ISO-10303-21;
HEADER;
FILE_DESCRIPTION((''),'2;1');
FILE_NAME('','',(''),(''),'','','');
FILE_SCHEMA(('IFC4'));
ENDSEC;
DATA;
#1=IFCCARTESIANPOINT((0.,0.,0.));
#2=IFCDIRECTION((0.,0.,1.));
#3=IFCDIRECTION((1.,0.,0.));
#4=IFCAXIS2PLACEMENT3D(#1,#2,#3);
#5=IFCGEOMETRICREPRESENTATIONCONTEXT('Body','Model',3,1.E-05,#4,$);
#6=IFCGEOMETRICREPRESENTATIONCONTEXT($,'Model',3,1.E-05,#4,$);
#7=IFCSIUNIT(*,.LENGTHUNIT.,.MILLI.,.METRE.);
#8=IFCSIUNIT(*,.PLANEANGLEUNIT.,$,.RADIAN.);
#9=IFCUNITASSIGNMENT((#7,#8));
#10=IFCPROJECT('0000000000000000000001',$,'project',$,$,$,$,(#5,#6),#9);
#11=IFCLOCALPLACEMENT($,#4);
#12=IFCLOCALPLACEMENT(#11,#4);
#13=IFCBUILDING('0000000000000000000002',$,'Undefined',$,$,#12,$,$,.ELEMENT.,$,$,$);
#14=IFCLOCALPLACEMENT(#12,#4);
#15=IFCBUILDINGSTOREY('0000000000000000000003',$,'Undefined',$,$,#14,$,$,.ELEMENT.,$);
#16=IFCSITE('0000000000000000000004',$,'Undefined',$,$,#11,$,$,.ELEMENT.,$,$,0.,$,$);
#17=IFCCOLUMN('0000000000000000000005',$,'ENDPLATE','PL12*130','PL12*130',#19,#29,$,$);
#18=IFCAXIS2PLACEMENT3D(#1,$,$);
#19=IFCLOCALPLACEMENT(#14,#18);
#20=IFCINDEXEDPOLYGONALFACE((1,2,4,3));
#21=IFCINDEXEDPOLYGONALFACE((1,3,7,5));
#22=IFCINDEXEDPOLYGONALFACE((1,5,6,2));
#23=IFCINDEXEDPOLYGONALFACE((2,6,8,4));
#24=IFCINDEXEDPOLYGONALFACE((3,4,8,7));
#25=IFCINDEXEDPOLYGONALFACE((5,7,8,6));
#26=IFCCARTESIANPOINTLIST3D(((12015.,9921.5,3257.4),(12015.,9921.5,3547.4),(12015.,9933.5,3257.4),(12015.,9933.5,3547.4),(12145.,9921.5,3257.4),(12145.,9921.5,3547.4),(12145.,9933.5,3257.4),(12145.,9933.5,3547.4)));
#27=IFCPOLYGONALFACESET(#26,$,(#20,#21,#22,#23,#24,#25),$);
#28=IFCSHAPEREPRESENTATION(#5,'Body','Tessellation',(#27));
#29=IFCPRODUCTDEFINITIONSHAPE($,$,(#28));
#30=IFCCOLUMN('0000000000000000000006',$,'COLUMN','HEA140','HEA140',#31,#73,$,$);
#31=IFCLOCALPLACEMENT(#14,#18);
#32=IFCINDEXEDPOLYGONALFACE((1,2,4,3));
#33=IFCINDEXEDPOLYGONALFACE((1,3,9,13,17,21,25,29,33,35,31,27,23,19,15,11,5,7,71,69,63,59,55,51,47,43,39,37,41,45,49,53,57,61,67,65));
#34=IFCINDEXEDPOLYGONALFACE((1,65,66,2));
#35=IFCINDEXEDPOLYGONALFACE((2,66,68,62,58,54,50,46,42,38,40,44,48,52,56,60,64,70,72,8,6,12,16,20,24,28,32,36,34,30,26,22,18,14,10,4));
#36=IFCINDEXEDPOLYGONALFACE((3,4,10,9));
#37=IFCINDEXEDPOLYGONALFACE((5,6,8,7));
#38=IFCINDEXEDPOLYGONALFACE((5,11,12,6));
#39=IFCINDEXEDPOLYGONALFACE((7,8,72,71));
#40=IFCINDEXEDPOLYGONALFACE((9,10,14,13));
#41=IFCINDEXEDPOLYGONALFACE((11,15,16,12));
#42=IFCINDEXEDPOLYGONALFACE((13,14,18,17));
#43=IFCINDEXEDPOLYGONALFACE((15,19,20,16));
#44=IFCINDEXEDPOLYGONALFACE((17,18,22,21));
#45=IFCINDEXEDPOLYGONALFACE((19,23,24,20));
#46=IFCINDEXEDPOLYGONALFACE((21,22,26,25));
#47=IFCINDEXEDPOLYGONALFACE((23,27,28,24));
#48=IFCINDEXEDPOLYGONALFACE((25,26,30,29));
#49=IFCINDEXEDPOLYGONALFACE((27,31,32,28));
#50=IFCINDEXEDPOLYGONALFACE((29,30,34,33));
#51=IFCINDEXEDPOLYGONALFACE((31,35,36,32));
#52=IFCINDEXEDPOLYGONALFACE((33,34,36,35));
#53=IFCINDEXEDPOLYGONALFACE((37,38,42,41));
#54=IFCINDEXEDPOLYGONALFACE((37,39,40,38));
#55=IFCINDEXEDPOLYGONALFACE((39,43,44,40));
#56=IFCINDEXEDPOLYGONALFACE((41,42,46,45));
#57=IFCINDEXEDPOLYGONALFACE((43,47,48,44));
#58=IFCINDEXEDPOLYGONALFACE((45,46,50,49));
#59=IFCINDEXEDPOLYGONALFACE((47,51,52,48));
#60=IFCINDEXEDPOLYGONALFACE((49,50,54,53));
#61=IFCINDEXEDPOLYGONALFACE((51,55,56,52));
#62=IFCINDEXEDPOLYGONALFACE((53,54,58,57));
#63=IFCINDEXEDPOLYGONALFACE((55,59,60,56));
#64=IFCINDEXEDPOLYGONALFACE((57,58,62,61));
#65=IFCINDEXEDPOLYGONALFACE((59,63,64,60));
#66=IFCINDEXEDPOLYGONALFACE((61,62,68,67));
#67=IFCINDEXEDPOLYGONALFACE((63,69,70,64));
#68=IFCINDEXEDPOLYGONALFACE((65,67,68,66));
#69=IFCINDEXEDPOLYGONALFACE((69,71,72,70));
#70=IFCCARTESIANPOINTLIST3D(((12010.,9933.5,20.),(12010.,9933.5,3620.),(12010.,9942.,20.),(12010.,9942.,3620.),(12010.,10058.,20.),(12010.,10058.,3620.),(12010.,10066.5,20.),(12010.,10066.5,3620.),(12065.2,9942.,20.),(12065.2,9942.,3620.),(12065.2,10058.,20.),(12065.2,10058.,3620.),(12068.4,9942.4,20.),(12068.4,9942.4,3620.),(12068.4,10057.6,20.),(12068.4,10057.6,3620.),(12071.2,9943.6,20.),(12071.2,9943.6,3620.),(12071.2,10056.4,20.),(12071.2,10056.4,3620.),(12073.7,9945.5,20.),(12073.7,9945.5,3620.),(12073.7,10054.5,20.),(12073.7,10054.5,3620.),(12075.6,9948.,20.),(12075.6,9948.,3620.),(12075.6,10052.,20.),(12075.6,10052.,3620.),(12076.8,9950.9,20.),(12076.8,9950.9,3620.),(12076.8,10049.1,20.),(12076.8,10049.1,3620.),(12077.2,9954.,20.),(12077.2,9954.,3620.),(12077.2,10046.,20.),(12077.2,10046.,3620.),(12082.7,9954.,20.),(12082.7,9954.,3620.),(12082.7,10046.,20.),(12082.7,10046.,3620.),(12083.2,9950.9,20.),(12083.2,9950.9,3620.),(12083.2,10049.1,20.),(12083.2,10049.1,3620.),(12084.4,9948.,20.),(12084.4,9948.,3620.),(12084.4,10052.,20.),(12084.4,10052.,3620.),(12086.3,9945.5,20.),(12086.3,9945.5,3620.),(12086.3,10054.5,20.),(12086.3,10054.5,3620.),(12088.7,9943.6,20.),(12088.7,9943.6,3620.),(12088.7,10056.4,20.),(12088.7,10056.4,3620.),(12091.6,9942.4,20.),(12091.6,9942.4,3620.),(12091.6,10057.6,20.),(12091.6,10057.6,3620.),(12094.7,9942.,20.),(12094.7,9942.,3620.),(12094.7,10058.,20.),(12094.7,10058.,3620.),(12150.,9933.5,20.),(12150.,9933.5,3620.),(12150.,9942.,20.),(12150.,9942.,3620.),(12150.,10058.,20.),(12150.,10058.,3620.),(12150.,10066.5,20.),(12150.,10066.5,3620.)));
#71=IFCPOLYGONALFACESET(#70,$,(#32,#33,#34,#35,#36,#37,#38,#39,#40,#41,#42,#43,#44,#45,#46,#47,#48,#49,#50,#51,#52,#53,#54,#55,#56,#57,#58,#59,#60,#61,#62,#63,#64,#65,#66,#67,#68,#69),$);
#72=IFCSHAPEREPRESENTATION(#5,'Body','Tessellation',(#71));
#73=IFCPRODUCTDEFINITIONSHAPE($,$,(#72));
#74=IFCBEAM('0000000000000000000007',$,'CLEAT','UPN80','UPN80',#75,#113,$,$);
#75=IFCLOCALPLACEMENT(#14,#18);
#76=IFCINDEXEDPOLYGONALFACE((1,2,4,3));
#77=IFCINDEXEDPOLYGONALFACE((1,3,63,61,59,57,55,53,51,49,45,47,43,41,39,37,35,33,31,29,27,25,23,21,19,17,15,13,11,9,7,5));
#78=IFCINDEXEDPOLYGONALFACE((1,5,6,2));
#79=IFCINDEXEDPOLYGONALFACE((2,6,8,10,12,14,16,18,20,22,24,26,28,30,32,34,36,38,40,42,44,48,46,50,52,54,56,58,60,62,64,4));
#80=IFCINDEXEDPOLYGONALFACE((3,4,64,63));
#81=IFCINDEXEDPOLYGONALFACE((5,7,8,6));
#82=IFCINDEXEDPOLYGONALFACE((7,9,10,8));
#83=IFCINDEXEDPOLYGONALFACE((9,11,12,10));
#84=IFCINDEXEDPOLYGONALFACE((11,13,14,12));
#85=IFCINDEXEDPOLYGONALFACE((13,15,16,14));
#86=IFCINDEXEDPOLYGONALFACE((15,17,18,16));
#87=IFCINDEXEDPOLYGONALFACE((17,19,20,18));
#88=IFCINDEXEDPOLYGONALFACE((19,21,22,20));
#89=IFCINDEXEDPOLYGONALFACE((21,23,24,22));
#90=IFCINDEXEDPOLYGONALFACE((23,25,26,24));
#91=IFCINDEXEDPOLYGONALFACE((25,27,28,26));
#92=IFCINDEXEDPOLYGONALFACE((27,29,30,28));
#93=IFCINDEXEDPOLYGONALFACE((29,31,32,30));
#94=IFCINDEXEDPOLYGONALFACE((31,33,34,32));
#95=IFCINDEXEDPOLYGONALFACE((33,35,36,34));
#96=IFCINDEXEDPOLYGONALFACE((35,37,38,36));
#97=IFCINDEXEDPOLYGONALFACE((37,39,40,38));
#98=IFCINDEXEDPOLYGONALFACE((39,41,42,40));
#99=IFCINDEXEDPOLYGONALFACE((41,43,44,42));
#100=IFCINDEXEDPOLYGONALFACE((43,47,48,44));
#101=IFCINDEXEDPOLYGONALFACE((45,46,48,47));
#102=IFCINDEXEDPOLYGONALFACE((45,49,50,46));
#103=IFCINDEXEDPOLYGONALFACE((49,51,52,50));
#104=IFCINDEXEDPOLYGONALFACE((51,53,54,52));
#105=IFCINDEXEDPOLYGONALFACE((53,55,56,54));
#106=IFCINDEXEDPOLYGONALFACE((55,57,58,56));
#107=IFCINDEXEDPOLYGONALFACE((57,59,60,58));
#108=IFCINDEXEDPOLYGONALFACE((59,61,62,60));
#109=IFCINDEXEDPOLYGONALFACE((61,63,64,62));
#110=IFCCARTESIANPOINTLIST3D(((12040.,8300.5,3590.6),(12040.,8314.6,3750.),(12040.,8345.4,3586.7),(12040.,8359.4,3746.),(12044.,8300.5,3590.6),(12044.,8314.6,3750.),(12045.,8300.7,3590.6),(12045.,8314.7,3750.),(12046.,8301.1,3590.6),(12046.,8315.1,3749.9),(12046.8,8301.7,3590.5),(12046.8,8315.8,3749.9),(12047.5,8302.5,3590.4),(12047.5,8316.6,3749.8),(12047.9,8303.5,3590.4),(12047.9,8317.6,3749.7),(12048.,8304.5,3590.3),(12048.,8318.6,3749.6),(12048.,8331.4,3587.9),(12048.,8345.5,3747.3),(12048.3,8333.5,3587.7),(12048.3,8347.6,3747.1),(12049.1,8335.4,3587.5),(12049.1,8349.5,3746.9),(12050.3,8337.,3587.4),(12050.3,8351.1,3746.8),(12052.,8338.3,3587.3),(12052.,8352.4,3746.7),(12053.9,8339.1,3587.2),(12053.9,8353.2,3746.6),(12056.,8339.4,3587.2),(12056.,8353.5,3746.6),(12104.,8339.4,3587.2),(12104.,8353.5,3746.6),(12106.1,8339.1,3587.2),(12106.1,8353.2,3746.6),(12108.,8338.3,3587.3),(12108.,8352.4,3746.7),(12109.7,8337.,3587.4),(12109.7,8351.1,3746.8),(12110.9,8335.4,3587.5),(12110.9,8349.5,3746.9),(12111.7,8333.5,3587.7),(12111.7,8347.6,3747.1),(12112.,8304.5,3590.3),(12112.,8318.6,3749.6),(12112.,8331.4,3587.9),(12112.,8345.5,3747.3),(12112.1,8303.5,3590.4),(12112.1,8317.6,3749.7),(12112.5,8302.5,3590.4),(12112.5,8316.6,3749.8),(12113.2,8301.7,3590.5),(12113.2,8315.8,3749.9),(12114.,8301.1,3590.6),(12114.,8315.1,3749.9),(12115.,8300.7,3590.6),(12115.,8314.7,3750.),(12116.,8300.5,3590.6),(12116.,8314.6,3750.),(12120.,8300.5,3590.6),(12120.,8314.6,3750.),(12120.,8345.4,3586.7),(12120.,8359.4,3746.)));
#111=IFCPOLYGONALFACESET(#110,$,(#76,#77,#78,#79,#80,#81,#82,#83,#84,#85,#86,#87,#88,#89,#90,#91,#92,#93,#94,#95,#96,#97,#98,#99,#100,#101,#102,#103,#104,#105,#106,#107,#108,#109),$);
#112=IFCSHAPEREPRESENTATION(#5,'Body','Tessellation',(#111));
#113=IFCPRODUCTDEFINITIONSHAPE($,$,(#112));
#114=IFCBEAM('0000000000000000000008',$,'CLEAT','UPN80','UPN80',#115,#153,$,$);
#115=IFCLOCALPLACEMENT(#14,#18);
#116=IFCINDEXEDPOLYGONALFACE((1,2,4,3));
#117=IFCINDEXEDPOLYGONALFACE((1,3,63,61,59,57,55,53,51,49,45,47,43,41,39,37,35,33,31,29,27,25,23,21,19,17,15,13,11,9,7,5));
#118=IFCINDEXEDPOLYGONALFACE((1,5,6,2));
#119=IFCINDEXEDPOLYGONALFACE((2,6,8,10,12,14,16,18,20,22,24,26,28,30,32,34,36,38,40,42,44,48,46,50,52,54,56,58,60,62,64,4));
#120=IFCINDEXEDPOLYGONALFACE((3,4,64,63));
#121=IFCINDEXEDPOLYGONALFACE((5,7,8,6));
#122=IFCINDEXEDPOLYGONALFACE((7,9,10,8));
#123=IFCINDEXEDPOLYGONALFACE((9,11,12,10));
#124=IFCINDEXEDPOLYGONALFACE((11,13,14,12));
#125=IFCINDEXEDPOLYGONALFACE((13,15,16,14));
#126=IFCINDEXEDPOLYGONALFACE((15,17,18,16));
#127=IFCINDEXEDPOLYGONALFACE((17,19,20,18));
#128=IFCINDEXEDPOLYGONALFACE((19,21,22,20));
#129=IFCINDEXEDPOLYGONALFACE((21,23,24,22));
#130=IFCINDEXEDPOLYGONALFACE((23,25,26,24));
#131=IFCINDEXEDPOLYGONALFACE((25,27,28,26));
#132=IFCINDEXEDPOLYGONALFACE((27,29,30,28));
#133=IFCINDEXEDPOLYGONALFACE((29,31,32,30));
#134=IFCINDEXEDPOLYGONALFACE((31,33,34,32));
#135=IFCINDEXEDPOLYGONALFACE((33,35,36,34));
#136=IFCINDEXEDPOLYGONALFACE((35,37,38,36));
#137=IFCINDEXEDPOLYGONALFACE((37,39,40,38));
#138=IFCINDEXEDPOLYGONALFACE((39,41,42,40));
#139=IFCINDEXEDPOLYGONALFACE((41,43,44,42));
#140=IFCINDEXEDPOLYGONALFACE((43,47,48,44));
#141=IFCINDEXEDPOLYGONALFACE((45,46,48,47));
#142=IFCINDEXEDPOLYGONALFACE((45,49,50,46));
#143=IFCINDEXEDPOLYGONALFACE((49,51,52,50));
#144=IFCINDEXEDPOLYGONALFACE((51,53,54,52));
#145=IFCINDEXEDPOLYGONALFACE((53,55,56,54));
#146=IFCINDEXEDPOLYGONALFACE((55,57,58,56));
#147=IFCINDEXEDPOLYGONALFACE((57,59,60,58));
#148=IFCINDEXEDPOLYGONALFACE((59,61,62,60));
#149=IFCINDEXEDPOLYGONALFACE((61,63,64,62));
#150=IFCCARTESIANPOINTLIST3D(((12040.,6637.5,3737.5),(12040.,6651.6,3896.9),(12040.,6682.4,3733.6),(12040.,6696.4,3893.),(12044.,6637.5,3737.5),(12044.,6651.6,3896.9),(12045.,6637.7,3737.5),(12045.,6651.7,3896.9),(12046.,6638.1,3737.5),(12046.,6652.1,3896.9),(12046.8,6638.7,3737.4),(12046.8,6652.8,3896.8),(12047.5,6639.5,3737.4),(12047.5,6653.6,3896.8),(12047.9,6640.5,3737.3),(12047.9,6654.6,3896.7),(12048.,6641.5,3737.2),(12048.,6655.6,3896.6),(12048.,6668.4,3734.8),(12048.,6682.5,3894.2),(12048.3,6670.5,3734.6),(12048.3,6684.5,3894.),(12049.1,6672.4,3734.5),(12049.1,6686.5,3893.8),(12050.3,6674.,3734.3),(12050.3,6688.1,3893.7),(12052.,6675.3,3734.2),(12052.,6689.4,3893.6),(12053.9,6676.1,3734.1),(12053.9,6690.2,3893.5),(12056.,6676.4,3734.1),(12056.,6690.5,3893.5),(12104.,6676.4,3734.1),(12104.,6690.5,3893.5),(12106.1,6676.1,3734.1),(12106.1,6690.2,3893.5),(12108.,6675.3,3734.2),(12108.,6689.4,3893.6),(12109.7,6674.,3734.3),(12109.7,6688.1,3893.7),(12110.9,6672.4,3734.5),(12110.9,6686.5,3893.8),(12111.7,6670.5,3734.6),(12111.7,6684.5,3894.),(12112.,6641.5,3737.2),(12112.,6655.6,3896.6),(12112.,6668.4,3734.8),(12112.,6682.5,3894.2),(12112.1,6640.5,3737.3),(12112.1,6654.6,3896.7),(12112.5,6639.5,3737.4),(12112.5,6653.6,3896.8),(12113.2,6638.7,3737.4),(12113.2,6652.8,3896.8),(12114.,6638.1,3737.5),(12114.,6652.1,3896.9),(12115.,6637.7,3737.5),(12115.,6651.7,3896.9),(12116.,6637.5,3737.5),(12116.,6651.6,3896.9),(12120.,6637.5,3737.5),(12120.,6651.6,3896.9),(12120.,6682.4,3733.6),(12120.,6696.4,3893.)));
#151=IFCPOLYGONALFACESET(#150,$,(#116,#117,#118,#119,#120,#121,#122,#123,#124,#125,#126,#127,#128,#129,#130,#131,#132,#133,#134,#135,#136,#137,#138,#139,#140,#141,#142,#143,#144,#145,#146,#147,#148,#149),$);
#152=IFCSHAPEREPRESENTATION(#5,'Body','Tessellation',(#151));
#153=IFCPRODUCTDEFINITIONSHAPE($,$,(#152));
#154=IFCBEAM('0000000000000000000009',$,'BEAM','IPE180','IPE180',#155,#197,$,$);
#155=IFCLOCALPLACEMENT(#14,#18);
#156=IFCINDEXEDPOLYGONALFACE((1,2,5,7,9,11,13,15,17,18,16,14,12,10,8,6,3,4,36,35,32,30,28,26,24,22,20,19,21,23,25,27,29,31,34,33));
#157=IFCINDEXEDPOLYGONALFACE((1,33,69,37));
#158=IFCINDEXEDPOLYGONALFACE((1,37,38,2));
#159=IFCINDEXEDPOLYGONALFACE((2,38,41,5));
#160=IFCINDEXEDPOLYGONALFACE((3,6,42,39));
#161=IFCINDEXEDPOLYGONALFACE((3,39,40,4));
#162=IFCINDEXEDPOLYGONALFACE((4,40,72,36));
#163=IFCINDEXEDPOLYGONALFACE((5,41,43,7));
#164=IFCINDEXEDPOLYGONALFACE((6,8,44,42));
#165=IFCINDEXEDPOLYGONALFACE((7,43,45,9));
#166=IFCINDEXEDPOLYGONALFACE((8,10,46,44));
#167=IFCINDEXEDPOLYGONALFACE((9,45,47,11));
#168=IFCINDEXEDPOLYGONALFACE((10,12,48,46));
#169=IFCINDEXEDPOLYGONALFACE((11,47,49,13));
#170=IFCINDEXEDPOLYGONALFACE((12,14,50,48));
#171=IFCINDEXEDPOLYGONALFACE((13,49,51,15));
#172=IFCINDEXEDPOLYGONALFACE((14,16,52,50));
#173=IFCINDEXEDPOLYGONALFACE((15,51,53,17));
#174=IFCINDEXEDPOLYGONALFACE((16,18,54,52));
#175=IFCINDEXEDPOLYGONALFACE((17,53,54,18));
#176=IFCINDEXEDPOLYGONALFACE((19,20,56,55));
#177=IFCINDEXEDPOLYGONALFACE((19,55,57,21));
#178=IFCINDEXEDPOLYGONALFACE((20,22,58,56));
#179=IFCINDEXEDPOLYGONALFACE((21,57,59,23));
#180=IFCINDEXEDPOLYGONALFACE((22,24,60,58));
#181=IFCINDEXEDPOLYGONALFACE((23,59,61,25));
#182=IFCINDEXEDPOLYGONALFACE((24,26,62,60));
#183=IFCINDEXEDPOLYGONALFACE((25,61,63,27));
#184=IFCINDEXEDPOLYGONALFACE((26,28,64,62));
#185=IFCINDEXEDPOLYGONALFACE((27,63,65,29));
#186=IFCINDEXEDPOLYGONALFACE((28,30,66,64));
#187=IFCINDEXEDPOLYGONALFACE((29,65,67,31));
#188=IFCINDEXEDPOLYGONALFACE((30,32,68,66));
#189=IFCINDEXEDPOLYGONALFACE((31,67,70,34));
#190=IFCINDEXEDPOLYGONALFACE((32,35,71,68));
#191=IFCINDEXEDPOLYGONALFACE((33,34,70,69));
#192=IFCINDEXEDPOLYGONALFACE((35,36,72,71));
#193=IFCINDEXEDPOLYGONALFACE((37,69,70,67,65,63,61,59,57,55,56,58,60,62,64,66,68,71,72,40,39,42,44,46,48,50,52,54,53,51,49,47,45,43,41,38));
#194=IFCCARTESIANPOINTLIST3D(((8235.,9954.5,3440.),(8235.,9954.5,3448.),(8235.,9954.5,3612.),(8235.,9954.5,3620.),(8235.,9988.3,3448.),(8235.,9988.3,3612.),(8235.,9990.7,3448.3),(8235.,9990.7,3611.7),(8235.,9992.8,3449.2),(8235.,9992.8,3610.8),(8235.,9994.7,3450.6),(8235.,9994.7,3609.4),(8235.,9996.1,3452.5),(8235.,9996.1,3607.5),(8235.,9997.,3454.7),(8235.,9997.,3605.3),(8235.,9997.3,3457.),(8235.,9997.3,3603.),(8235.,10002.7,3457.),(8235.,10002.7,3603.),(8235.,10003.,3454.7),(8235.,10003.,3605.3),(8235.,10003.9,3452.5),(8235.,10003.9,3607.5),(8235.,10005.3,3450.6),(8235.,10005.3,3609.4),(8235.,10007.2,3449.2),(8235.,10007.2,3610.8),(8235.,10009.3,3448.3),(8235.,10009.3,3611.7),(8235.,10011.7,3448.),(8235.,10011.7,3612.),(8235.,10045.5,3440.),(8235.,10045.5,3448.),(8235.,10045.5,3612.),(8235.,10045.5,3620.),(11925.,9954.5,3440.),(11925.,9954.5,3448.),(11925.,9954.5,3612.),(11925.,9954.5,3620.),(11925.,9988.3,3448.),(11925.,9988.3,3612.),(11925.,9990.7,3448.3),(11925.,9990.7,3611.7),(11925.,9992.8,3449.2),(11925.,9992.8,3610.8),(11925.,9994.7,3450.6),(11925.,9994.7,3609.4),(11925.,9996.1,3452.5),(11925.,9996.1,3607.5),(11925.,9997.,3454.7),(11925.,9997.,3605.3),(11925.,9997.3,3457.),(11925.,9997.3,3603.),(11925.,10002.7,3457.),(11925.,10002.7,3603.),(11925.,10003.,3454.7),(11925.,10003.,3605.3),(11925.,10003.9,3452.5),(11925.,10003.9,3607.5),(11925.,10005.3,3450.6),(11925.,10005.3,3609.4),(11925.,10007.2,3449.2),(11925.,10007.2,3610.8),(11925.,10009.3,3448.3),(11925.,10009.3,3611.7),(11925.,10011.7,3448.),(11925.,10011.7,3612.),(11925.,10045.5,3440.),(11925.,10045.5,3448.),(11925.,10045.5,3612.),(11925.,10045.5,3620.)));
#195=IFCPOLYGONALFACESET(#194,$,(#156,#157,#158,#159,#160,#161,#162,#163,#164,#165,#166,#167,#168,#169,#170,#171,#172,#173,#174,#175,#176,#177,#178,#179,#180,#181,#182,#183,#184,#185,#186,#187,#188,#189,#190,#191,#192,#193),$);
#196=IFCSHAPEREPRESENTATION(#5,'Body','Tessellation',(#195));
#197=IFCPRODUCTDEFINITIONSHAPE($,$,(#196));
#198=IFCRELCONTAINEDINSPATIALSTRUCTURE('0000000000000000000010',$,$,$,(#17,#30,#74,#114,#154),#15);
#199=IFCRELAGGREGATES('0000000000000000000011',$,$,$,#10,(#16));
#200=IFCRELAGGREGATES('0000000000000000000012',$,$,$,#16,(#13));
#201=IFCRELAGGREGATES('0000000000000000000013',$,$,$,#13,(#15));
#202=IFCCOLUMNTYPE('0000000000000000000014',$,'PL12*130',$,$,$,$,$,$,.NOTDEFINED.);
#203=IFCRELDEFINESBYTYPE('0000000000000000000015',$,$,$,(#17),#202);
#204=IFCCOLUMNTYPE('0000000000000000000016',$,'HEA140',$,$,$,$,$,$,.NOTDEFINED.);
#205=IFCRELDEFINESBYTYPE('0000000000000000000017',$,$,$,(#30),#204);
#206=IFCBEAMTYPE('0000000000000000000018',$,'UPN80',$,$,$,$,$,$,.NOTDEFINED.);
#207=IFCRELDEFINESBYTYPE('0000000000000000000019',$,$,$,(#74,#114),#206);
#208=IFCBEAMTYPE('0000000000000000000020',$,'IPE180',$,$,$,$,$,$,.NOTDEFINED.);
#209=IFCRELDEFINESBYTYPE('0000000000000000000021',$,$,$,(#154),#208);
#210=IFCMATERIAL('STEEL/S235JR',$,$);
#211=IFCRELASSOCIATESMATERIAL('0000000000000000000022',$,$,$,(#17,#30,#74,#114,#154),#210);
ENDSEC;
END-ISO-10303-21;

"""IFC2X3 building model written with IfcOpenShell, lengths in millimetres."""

from ifc_helpers import new_model, si_unit, frame, origin_with_axes, origin_2d_with_axis, place, context, project, spatial, rectangle, i_section, u_section, extrude, material, type_object, element, save


model = new_model("IFC2X3")

# Units and contexts
model_context_1 = context("Model", 3, precision=1e-05, world=origin_with_axes(), identifier="Body")
model_context_2 = context("Model", 3, precision=1e-05, world=origin_with_axes())
ifc_project = project(units=[si_unit("LENGTHUNIT", "METRE", prefix="MILLI"), si_unit("PLANEANGLEUNIT", "RADIAN")], contexts=[model_context_1, model_context_2])

# Site, building, storey
site_placement = place(None, origin_with_axes())
site = spatial("IfcSite", under=ifc_project, at=site_placement, Name="Undefined", CompositionType="ELEMENT", RefElevation=0.0)
building_placement = place(site_placement, origin_with_axes())
building = spatial("IfcBuilding", under=site, at=building_placement, Name="Undefined", CompositionType="ELEMENT")
storey_placement = place(building_placement, origin_with_axes())
storey = spatial("IfcBuildingStorey", under=building, at=storey_placement, Name="Undefined", CompositionType="ELEMENT")

# Columns
ifc_material = material(Name="STEEL/S235JR")
column_type_1 = type_object("IfcColumnType", Name="PL12*130", PredefinedType="NOTDEFINED")
column_1_placement = place(storey_placement, frame((12080.0, 9927.5, 3257.4), z_axis=(0.0, 0.0, 1.0), x_axis=(1.0, 0.0, 0.0)))
element("IfcColumn", 1, at=column_1_placement, inside=storey, type_object=column_type_1, material=ifc_material, Name="ENDPLATE", Description="PL12*130", ObjectType="PL12*130", context=model_context_1, shape_type="SweptSolid", body=[
    extrude(rectangle(XDim=12.0, YDim=130.0, at=origin_2d_with_axis()), frame((0.0, 0.0, 290.0), z_axis=(0.0, 0.0, -1.0), x_axis=(0.0, -1.0, 0.0)), (0.0, 0.0, 1.0), 290.0),
])
column_type_2 = type_object("IfcColumnType", Name="HEA140", PredefinedType="NOTDEFINED")
column_2_placement = place(storey_placement, frame((12080.0, 10000.0, -180.0), z_axis=(0.0, 0.0, 1.0), x_axis=(1.0, 0.0, 0.0)))
element("IfcColumn", 2, at=column_2_placement, inside=storey, type_object=column_type_2, material=ifc_material, Name="COLUMN", Description="HEA140", ObjectType="HEA140", context=model_context_1, shape_type="SweptSolid", body=[
    extrude(i_section(OverallWidth=140.0, OverallDepth=133.0, WebThickness=5.5, FlangeThickness=8.5, FilletRadius=12.0, at=origin_2d_with_axis()), frame((0.0, 0.0, 3800.0), z_axis=(0.0, 0.0, -1.0), x_axis=(-1.0, 0.0, 0.0)), (0.0, 0.0, 1.0), 3600.0),
])

# Beams
beam_type_1 = type_object("IfcBeamType", Name="UPN80", PredefinedType="NOTDEFINED")
for number, where, z_axis, x_axis, name in (
    (3, (12080.0, 8322.9, 3588.6), (-1.0, 0.0, 0.0), (0.0, 0.08801, 0.99612), "CLEAT"),
    (4, (12080.0, 6659.9, 3735.6), (-1.0, 0.0, 0.0), (0.0, 0.08801, 0.99612), "CLEAT"),
):
    element("IfcBeam", number, at=place(storey_placement, frame(where, z_axis=z_axis, x_axis=x_axis)), inside=storey, type_object=beam_type_1, material=ifc_material, Name=name, Description="UPN80", ObjectType="UPN80", context=model_context_1, shape_type="SweptSolid", body=[
        extrude(u_section(Depth=80.0, FlangeWidth=45.0, WebThickness=6.0, FlangeThickness=8.0, FilletRadius=8.0, EdgeRadius=4.0, at=origin_2d_with_axis()), frame((160.0, 0.0, 0.0), z_axis=(-1.0, 0.0, 0.0), x_axis=(0.0, -1.0, 0.0)), (0.0, 0.0, 1.0), 160.0),
    ])
beam_type_2 = type_object("IfcBeamType", Name="IPE180", PredefinedType="NOTDEFINED")
beam_1_placement = place(storey_placement, frame((8235.0, 10000.0, 3530.0), z_axis=(0.0, 0.0, 1.0), x_axis=(1.0, 0.0, 0.0)))
element("IfcBeam", 5, at=beam_1_placement, inside=storey, type_object=beam_type_2, material=ifc_material, Name="BEAM", Description="IPE180", ObjectType="IPE180", context=model_context_1, shape_type="SweptSolid", body=[
    extrude(i_section(OverallWidth=91.0, OverallDepth=180.0, WebThickness=5.3, FlangeThickness=8.0, FilletRadius=9.0, at=origin_2d_with_axis()), frame((3690.0, 0.0, 0.0), z_axis=(-1.0, 0.0, 0.0), x_axis=(0.0, -1.0, 0.0)), (0.0, 0.0, 1.0), 3690.0),
])

save(model, "model.ifc")
